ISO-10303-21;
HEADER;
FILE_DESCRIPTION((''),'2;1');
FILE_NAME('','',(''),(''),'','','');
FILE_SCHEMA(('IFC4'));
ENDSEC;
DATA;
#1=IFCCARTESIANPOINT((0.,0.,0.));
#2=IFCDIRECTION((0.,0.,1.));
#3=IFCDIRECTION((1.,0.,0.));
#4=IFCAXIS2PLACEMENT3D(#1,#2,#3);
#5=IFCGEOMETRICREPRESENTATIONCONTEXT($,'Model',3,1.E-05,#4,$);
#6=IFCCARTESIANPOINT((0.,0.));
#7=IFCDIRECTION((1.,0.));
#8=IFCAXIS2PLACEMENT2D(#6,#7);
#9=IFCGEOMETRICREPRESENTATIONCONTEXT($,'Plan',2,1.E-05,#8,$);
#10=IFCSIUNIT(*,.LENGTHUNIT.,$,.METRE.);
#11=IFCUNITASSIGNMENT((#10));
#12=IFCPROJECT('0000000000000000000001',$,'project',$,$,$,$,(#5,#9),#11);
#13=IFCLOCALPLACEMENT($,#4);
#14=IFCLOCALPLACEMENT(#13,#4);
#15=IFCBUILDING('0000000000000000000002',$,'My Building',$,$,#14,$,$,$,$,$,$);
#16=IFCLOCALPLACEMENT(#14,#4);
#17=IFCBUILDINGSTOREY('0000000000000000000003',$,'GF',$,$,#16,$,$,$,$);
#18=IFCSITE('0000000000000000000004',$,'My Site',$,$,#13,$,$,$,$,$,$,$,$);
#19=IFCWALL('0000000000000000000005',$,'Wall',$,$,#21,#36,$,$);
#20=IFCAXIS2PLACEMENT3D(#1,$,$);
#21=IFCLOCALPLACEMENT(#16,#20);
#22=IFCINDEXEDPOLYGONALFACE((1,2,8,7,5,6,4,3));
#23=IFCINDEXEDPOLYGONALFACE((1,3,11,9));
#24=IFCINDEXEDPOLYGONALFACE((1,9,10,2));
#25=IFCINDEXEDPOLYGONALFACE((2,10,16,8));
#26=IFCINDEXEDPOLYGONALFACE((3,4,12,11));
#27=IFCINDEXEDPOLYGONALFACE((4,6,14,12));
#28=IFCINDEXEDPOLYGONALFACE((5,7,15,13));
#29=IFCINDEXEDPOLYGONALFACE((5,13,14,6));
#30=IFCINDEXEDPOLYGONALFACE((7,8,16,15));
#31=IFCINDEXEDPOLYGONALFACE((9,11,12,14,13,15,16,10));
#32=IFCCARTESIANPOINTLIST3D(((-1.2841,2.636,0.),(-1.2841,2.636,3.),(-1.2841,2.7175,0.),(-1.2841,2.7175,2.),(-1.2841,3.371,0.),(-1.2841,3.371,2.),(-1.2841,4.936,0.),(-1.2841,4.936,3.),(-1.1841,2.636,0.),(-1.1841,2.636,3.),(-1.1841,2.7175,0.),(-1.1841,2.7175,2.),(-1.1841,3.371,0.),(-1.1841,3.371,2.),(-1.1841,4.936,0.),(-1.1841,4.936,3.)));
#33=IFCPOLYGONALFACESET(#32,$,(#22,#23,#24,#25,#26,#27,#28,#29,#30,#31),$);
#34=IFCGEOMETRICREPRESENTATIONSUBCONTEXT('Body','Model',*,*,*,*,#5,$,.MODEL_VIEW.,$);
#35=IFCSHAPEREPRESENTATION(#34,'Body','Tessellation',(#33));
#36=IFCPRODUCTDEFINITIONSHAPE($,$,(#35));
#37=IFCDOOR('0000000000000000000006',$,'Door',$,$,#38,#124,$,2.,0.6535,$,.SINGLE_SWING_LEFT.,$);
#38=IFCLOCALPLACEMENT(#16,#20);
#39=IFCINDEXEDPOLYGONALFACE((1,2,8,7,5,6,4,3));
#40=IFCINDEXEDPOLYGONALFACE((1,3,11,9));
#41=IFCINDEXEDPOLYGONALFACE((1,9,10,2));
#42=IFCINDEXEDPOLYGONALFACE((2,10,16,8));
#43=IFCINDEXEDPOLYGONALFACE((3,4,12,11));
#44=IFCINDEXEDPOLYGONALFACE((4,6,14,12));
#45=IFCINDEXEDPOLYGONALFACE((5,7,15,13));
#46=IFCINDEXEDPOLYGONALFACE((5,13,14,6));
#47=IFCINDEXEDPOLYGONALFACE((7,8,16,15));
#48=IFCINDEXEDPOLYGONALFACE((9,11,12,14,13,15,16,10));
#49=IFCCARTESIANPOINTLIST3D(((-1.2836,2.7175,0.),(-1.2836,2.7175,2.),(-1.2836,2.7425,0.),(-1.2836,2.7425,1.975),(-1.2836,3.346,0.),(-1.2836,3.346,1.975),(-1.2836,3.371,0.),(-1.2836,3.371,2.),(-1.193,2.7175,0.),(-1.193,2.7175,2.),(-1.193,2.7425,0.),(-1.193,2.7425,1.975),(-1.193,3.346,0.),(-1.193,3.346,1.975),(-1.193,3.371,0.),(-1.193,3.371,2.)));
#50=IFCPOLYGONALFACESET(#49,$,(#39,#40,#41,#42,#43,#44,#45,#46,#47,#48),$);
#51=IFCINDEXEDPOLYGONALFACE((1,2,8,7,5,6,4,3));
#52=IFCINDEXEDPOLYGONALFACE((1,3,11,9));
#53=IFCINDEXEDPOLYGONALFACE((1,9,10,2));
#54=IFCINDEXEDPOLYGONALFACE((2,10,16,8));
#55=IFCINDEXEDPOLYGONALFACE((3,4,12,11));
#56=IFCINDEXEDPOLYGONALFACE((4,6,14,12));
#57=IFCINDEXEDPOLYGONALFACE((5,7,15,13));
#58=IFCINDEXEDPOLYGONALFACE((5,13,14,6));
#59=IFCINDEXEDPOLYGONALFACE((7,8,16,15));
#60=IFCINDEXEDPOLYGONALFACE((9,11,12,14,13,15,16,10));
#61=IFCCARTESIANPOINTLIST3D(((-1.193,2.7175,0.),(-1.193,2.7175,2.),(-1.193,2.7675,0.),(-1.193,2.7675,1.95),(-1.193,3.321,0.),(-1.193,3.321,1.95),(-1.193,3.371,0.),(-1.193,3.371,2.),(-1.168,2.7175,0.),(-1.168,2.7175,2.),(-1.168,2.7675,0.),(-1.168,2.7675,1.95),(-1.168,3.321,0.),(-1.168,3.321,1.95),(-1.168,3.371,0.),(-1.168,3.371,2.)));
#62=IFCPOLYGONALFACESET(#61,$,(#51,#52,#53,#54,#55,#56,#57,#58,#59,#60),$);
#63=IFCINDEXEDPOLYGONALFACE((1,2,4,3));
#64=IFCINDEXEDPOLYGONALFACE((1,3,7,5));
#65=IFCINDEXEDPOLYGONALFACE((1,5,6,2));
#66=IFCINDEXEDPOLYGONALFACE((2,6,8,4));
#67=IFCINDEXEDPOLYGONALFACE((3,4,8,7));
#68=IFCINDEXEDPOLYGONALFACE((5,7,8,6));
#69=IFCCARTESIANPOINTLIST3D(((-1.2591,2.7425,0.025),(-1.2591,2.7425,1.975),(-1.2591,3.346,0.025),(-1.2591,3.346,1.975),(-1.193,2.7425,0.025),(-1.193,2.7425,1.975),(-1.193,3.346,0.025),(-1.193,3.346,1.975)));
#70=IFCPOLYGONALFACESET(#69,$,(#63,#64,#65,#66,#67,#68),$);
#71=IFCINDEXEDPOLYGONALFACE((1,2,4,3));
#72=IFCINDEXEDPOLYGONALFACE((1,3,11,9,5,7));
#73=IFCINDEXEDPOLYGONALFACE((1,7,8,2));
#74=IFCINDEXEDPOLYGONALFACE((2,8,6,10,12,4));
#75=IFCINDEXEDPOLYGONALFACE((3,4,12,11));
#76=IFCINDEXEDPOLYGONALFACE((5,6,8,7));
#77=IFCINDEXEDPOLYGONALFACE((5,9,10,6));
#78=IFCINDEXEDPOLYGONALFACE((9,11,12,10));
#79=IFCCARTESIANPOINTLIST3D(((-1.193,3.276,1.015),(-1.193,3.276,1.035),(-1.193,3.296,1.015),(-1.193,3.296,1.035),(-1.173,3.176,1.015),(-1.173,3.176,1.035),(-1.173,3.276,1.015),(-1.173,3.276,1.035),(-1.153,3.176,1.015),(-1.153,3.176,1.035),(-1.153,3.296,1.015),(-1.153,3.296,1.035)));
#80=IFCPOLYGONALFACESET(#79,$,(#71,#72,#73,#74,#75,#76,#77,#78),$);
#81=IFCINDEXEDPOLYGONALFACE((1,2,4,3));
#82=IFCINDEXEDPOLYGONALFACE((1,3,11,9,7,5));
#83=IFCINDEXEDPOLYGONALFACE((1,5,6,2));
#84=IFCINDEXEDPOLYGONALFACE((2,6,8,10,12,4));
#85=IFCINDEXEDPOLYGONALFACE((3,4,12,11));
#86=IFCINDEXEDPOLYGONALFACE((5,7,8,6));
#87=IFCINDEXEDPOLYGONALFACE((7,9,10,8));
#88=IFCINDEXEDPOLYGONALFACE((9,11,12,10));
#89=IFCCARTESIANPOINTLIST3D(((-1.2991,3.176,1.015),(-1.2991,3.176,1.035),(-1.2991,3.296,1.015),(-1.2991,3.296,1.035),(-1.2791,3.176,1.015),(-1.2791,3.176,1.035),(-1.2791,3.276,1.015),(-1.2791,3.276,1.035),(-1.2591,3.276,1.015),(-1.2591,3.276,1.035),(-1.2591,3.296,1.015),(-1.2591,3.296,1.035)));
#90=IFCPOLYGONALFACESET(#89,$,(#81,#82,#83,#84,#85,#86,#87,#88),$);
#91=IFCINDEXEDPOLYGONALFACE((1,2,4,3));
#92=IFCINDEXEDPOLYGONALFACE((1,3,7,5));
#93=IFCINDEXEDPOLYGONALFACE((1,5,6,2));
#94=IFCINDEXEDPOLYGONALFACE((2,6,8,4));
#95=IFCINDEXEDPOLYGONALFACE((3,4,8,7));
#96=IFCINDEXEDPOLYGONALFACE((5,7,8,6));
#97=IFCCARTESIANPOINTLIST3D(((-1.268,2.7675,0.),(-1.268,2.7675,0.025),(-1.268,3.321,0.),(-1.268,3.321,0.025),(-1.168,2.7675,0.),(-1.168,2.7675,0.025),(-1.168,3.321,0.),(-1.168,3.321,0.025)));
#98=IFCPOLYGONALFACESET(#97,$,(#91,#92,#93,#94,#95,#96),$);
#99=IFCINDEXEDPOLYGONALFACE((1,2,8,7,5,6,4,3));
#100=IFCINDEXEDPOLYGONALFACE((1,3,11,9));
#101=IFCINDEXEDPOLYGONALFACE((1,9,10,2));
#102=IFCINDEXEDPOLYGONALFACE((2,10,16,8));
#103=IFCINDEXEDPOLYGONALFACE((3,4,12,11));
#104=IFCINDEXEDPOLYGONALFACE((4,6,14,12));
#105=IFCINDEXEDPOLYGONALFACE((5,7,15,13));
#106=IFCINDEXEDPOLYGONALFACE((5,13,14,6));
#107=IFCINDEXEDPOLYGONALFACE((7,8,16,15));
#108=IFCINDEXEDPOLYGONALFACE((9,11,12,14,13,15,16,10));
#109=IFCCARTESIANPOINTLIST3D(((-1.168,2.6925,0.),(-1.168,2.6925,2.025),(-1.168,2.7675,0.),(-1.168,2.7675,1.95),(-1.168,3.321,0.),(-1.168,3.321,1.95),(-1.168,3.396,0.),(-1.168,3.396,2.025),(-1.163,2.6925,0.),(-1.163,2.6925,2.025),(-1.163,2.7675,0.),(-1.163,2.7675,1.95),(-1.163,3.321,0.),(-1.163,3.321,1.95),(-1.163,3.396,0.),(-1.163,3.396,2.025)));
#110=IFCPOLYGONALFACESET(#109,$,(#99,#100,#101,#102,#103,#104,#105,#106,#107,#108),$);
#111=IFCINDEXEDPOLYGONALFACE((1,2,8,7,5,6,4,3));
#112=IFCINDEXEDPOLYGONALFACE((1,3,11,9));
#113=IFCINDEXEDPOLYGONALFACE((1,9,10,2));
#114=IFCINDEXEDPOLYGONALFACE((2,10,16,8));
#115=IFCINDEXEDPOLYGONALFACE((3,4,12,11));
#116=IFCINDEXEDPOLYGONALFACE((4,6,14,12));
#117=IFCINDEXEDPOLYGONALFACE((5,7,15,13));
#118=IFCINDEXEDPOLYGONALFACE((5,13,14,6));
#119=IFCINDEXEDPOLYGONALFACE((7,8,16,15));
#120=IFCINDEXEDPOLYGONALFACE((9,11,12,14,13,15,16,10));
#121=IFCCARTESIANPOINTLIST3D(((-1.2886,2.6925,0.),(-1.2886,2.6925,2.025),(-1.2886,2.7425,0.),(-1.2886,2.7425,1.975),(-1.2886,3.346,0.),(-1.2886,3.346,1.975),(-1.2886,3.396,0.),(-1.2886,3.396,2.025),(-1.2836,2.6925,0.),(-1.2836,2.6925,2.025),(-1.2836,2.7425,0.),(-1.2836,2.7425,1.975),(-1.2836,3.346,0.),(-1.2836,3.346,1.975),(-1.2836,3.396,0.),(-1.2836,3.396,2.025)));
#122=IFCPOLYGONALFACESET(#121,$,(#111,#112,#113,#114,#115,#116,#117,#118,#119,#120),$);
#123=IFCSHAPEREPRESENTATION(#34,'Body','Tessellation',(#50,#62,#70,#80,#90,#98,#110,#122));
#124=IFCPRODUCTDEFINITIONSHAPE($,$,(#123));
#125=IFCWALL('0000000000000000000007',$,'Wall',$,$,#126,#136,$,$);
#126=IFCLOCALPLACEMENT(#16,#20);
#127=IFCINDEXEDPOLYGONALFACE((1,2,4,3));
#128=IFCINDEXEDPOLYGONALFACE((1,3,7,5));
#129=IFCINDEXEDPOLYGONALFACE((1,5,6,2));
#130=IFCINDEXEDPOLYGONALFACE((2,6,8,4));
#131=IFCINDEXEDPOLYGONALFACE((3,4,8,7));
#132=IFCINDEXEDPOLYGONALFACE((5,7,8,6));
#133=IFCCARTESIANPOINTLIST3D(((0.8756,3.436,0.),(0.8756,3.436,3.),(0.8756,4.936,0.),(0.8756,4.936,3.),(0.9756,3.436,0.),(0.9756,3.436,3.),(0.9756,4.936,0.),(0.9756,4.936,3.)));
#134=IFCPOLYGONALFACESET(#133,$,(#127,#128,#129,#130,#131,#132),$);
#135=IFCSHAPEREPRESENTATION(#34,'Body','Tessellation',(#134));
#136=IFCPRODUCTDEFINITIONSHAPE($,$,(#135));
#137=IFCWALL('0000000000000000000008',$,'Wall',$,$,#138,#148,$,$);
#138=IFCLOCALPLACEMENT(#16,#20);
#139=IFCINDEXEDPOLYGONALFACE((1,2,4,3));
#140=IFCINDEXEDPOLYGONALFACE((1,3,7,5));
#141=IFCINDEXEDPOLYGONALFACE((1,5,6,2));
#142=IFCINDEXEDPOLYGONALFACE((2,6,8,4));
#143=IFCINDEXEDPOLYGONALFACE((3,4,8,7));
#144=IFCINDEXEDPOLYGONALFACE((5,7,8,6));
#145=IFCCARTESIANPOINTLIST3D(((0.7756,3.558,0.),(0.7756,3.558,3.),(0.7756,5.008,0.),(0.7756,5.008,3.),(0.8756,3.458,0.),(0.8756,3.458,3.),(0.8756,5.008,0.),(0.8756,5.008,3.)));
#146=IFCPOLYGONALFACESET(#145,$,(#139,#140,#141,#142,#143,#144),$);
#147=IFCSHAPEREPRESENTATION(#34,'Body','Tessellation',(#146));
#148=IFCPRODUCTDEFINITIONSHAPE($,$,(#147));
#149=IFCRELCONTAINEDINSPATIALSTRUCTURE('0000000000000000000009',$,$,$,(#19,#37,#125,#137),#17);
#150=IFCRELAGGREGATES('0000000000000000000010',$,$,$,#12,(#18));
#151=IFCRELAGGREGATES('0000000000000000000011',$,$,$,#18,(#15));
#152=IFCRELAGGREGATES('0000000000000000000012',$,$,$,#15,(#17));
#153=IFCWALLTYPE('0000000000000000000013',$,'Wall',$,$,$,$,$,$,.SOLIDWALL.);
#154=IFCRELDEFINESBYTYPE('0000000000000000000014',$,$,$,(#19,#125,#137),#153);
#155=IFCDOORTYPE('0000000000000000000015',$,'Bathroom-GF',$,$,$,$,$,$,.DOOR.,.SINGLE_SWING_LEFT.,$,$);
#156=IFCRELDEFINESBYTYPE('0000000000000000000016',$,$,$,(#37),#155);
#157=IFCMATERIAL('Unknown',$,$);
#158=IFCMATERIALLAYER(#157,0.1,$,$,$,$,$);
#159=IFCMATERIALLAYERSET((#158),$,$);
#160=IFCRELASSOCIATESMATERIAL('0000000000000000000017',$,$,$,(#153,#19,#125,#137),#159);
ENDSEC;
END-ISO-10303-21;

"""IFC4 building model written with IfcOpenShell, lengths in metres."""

from ifc_helpers import new_model, entity, si_unit, frame, origin_with_axes, origin_2d_with_axis, place, context, subcontext, project, spatial, line, indexed_curve, outline, extrude, shape, source, transform, mapped, material, layer, layer_set, layer_usage, type_object, type_shapes, element, fill, save


model = new_model("IFC4")

# Units and contexts
model_context = context("Model", 3, precision=1e-05, world=origin_with_axes())
plan_context = context("Plan", 2, precision=1e-05, world=origin_2d_with_axis())
body_context_1 = subcontext(model_context, "Body", "Model", "MODEL_VIEW")
body_context_2 = subcontext(plan_context, "Body", "Plan", "PLAN_VIEW")
ifc_project = project(units=[si_unit("LENGTHUNIT", "METRE")], contexts=[model_context, plan_context])

# Site, building, storey
site_placement = place(None, origin_with_axes())
site = spatial("IfcSite", under=ifc_project, at=site_placement, Name="My Site")
building_placement = place(site_placement, origin_with_axes())
building = spatial("IfcBuilding", under=site, at=building_placement, Name="My Building")
storey_placement = place(building_placement, origin_with_axes())
storey = spatial("IfcBuildingStorey", under=building, at=storey_placement, Name="GF")

# Shared definitions
ifc_material = material(Name="Unknown")

# Shared definitions
ifc_layer_1 = layer(ifc_material, 0.1)
ifc_layer_set_1 = layer_set([ifc_layer_1])
wall_type = type_object("IfcWallType", Name="Wall", PredefinedType="SOLIDWALL", material=ifc_layer_set_1)

# Wall, opening, door
ifc_layer_usage_1 = layer_usage(ifc_layer_set_1, "AXIS2", "POSITIVE", 0.0)
wall_1_placement = place(storey_placement, frame((-1.1841, 2.636, 0.0), z_axis=(0.0, 0.0, 1.0), x_axis=(0.0, 1.0, 0.0)))
wall_1 = element("IfcWall", 1, at=wall_1_placement, inside=storey, type_object=wall_type, material=ifc_layer_usage_1, Name="Wall", context=body_context_1, shape_type="SweptSolid", body=[
    extrude(outline(indexed_curve([(0.0, 0.0), (0.0, 0.1), (2.3, 0.1), (2.3, 0.0)], segments=[line(1, 2, 3, 4, 1)])), origin_with_axes(), (0.0, 0.0, 1.0), 3.0),
])
shared_shape_1 = source(origin_with_axes(), body_context_1, "Body", "SweptSolid", [
    extrude(outline(indexed_curve([(0.0, 0.0), (0.6535, 0.0), (0.6535, 2.0), (0.0, 2.0)], segments=[line(1, 2, 3, 4, 1)])), frame((0.0, -0.6, 0.0), z_axis=(0.0, -1.0, 0.0), x_axis=(1.0, 0.0, 0.0)), (0.0, 0.0, -1.0), 1.2),
])
opening_1_placement = place(wall_1_placement, frame((0.0815, -0.0161, 0.0), z_axis=(0.0, 0.0, 1.0), x_axis=(1.0, 0.0, 0.0)))
opening_1 = element("IfcOpeningElement", 2, at=opening_1_placement, cuts=wall_1, PredefinedType="OPENING", context=body_context_1, shape_type="MappedRepresentation", body=[
    mapped(shared_shape_1, transform((0.0, 0.0, 0.0), x_axis=(1.0, 0.0, 0.0), y_axis=(0.0, 1.0, 0.0), z_axis=(0.0, 0.0, 1.0), scale=1.0)),
])
door_type_1 = type_object("IfcDoorType", Name="Bathroom-GF", OperationType="SINGLE_SWING_LEFT", PredefinedType="DOOR")
shared_shape_2 = source(origin_with_axes(), body_context_1, "Body", "SweptSolid", [
    extrude(outline(indexed_curve([(0.0, 0.0), (0.0, 2.0), (0.6535, 2.0), (0.6535, 0.0), (0.6285, 0.0), (0.6285, 1.975), (0.025, 1.975), (0.025, 0.0)], segments=[line(1, 2, 3, 4, 5, 6, 7, 8, 1)])), frame((0.0, 0.025, 0.0), z_axis=(0.0, -1.0, 0.0), x_axis=(1.0, 0.0, 0.0)), (0.0, 0.0, -1.0), 0.0906),
    extrude(outline(indexed_curve([(0.0, 0.0), (0.0, 2.0), (0.6535, 2.0), (0.6535, 0.0), (0.6035, 0.0), (0.6035, 1.95), (0.05, 1.95), (0.05, 0.0)], segments=[line(1, 2, 3, 4, 5, 6, 7, 8, 1)])), frame((0.0, 0.0, 0.0), z_axis=(0.0, -1.0, 0.0), x_axis=(1.0, 0.0, 0.0)), (0.0, 0.0, -1.0), 0.025),
    extrude(outline(indexed_curve([(0.0, 0.0), (0.6035, 0.0), (0.6035, 0.0661), (0.0, 0.0661)], segments=[line(1, 2, 3, 4, 1)])), frame((0.025, 0.025, 0.025), z_axis=(0.0, 0.0, 1.0), x_axis=(1.0, 0.0, 0.0)), (0.0, 0.0, 1.0), 1.95),
    extrude(outline(indexed_curve([(0.0, 0.0), (0.0, -0.04), (-0.12, -0.04), (-0.12, -0.02), (-0.02, -0.02), (-0.02, 0.0)], segments=[line(1, 2, 3, 4, 5, 6, 1)])), frame((0.5785, 0.025, 1.015), z_axis=(0.0, 0.0, 1.0), x_axis=(1.0, 0.0, 0.0)), (0.0, 0.0, 1.0), 0.02),
    extrude(outline(indexed_curve([(0.0, 0.0), (0.0, 0.04), (-0.12, 0.04), (-0.12, 0.02), (-0.02, 0.02), (-0.02, 0.0)], segments=[line(1, 2, 3, 4, 5, 6, 1)])), frame((0.5785, 0.0911, 1.015), z_axis=(0.0, 0.0, 1.0), x_axis=(1.0, 0.0, 0.0)), (0.0, 0.0, 1.0), 0.02),
    extrude(outline(indexed_curve([(0.0, 0.0), (0.5535, 0.0), (0.5535, 0.1), (0.0, 0.1)], segments=[line(1, 2, 3, 4, 1)])), frame((0.05, 0.0, 0.0), z_axis=(0.0, 0.0, 1.0), x_axis=(1.0, 0.0, 0.0)), (0.0, 0.0, 1.0), 0.025),
    extrude(outline(indexed_curve([(0.0, 0.0), (0.0, 2.025), (0.7035, 2.025), (0.7035, 0.0), (0.6285, 0.0), (0.6285, 1.95), (0.075, 1.95), (0.075, 0.0)], segments=[line(1, 2, 3, 4, 5, 6, 7, 8, 1)])), frame((-0.025, -0.005, 0.0), z_axis=(0.0, -1.0, 0.0), x_axis=(1.0, 0.0, 0.0)), (0.0, 0.0, -1.0), 0.005),
    extrude(outline(indexed_curve([(0.0, 0.0), (0.0, 2.025), (0.7035, 2.025), (0.7035, 0.0), (0.6535, 0.0), (0.6535, 1.975), (0.05, 1.975), (0.05, 0.0)], segments=[line(1, 2, 3, 4, 5, 6, 7, 8, 1)])), frame((-0.025, 0.1156, 0.0), z_axis=(0.0, -1.0, 0.0), x_axis=(1.0, 0.0, 0.0)), (0.0, 0.0, -1.0), 0.005),
])
shared_shape_3 = source(origin_with_axes(), body_context_2, "Body", "Curve2D", [
    entity("IfcIndexedPolyCurve", entity("IfcCartesianPointList2D", [[0.0, 0.0], [0.0, 0.1156], [0.025, 0.1156], [0.025, 0.025], [0.05, 0.025], [0.05, 0.0]]), [entity("IfcLineIndex", [1, 2, 3, 4, 5, 6, 1])]),
    entity("IfcIndexedPolyCurve", entity("IfcCartesianPointList2D", [[0.6535, 0.0], [0.6535, 0.1156], [0.6285, 0.1156], [0.6285, 0.025], [0.6035, 0.025], [0.6035, 0.0]]), [entity("IfcLineIndex", [1, 2, 3, 4, 5, 6, 1])]),
    entity("IfcTrimmedCurve", entity("IfcEllipse", entity("IfcAxis2Placement2D", entity("IfcCartesianPoint", [0.0911, 0.1156]), entity("IfcDirection", [1.0, 0.0])), 0.5374, 0.6035), [entity("IfcCartesianPoint", [0.6285, 0.1156])], [entity("IfcCartesianPoint", [0.0911, 0.7191])], True, "CARTESIAN"),
    entity("IfcIndexedPolyCurve", entity("IfcCartesianPointList2D", [[0.025, 0.1156], [0.0911, 0.1156], [0.0911, 0.7191], [0.025, 0.7191]]), [entity("IfcLineIndex", [1, 2, 3, 4, 1])]),
])
type_shapes(door_type_1, [shared_shape_2, shared_shape_3])
door_1_placement = place(opening_1_placement, origin_with_axes())
door_1 = element("IfcDoor", 3, at=door_1_placement, inside=storey, type_object=door_type_1, Name="Door", OperationType="SINGLE_SWING_LEFT", OverallHeight=2.0, OverallWidth=0.6535, shapes=[
    shape(body_context_1, "Body", "MappedRepresentation", [mapped(shared_shape_2, transform((0.0, 0.0, 0.0), x_axis=(1.0, 0.0, 0.0), y_axis=(0.0, 1.0, 0.0), z_axis=(0.0, 0.0, 1.0), scale=1.0))]),
    shape(body_context_2, "Body", "MappedRepresentation", [mapped(shared_shape_3, transform((0.0, 0.0, 0.0), x_axis=(1.0, 0.0, 0.0), y_axis=(0.0, 1.0, 0.0), z_axis=(0.0, 0.0, 1.0), scale=1.0))]),
])
fill(opening_1, door_1)

# Walls
ifc_layer_usage_2 = layer_usage(ifc_layer_set_1, "AXIS2", "POSITIVE", 0.0)
wall_2_placement = place(storey_placement, frame((0.8756, 4.936, 0.0), z_axis=(0.0, 0.0, 1.0), x_axis=(0.0, -1.0, 0.0)))
element("IfcWall", 4, at=wall_2_placement, inside=storey, type_object=wall_type, material=ifc_layer_usage_2, Name="Wall", context=body_context_1, shape_type="SweptSolid", body=[
    extrude(outline(indexed_curve([(0.0, 0.0), (0.0, 0.1), (1.5, 0.1), (1.5, 0.0)], segments=[line(1, 2, 3, 4, 1)])), origin_with_axes(), (0.0, 0.0, 1.0), 3.0),
])
ifc_layer_usage_3 = layer_usage(ifc_layer_set_1, "AXIS2", "POSITIVE", 0.0)
wall_3_placement = place(storey_placement, frame((0.7756, 5.008, 0.0), z_axis=(0.0, 0.0, 1.0), x_axis=(0.0, -1.0, 0.0)))
element("IfcWall", 5, at=wall_3_placement, inside=storey, type_object=wall_type, material=ifc_layer_usage_3, Name="Wall", context=body_context_1, shape_type="SweptSolid", body=[
    extrude(outline(indexed_curve([(0.0, 0.0), (0.0, 0.1), (1.55, 0.1), (1.45, 0.0)], segments=[line(1, 2, 3, 4, 1)])), origin_with_axes(), (0.0, 0.0, 1.0), 3.0),
])

save(model, "model.ifc")
